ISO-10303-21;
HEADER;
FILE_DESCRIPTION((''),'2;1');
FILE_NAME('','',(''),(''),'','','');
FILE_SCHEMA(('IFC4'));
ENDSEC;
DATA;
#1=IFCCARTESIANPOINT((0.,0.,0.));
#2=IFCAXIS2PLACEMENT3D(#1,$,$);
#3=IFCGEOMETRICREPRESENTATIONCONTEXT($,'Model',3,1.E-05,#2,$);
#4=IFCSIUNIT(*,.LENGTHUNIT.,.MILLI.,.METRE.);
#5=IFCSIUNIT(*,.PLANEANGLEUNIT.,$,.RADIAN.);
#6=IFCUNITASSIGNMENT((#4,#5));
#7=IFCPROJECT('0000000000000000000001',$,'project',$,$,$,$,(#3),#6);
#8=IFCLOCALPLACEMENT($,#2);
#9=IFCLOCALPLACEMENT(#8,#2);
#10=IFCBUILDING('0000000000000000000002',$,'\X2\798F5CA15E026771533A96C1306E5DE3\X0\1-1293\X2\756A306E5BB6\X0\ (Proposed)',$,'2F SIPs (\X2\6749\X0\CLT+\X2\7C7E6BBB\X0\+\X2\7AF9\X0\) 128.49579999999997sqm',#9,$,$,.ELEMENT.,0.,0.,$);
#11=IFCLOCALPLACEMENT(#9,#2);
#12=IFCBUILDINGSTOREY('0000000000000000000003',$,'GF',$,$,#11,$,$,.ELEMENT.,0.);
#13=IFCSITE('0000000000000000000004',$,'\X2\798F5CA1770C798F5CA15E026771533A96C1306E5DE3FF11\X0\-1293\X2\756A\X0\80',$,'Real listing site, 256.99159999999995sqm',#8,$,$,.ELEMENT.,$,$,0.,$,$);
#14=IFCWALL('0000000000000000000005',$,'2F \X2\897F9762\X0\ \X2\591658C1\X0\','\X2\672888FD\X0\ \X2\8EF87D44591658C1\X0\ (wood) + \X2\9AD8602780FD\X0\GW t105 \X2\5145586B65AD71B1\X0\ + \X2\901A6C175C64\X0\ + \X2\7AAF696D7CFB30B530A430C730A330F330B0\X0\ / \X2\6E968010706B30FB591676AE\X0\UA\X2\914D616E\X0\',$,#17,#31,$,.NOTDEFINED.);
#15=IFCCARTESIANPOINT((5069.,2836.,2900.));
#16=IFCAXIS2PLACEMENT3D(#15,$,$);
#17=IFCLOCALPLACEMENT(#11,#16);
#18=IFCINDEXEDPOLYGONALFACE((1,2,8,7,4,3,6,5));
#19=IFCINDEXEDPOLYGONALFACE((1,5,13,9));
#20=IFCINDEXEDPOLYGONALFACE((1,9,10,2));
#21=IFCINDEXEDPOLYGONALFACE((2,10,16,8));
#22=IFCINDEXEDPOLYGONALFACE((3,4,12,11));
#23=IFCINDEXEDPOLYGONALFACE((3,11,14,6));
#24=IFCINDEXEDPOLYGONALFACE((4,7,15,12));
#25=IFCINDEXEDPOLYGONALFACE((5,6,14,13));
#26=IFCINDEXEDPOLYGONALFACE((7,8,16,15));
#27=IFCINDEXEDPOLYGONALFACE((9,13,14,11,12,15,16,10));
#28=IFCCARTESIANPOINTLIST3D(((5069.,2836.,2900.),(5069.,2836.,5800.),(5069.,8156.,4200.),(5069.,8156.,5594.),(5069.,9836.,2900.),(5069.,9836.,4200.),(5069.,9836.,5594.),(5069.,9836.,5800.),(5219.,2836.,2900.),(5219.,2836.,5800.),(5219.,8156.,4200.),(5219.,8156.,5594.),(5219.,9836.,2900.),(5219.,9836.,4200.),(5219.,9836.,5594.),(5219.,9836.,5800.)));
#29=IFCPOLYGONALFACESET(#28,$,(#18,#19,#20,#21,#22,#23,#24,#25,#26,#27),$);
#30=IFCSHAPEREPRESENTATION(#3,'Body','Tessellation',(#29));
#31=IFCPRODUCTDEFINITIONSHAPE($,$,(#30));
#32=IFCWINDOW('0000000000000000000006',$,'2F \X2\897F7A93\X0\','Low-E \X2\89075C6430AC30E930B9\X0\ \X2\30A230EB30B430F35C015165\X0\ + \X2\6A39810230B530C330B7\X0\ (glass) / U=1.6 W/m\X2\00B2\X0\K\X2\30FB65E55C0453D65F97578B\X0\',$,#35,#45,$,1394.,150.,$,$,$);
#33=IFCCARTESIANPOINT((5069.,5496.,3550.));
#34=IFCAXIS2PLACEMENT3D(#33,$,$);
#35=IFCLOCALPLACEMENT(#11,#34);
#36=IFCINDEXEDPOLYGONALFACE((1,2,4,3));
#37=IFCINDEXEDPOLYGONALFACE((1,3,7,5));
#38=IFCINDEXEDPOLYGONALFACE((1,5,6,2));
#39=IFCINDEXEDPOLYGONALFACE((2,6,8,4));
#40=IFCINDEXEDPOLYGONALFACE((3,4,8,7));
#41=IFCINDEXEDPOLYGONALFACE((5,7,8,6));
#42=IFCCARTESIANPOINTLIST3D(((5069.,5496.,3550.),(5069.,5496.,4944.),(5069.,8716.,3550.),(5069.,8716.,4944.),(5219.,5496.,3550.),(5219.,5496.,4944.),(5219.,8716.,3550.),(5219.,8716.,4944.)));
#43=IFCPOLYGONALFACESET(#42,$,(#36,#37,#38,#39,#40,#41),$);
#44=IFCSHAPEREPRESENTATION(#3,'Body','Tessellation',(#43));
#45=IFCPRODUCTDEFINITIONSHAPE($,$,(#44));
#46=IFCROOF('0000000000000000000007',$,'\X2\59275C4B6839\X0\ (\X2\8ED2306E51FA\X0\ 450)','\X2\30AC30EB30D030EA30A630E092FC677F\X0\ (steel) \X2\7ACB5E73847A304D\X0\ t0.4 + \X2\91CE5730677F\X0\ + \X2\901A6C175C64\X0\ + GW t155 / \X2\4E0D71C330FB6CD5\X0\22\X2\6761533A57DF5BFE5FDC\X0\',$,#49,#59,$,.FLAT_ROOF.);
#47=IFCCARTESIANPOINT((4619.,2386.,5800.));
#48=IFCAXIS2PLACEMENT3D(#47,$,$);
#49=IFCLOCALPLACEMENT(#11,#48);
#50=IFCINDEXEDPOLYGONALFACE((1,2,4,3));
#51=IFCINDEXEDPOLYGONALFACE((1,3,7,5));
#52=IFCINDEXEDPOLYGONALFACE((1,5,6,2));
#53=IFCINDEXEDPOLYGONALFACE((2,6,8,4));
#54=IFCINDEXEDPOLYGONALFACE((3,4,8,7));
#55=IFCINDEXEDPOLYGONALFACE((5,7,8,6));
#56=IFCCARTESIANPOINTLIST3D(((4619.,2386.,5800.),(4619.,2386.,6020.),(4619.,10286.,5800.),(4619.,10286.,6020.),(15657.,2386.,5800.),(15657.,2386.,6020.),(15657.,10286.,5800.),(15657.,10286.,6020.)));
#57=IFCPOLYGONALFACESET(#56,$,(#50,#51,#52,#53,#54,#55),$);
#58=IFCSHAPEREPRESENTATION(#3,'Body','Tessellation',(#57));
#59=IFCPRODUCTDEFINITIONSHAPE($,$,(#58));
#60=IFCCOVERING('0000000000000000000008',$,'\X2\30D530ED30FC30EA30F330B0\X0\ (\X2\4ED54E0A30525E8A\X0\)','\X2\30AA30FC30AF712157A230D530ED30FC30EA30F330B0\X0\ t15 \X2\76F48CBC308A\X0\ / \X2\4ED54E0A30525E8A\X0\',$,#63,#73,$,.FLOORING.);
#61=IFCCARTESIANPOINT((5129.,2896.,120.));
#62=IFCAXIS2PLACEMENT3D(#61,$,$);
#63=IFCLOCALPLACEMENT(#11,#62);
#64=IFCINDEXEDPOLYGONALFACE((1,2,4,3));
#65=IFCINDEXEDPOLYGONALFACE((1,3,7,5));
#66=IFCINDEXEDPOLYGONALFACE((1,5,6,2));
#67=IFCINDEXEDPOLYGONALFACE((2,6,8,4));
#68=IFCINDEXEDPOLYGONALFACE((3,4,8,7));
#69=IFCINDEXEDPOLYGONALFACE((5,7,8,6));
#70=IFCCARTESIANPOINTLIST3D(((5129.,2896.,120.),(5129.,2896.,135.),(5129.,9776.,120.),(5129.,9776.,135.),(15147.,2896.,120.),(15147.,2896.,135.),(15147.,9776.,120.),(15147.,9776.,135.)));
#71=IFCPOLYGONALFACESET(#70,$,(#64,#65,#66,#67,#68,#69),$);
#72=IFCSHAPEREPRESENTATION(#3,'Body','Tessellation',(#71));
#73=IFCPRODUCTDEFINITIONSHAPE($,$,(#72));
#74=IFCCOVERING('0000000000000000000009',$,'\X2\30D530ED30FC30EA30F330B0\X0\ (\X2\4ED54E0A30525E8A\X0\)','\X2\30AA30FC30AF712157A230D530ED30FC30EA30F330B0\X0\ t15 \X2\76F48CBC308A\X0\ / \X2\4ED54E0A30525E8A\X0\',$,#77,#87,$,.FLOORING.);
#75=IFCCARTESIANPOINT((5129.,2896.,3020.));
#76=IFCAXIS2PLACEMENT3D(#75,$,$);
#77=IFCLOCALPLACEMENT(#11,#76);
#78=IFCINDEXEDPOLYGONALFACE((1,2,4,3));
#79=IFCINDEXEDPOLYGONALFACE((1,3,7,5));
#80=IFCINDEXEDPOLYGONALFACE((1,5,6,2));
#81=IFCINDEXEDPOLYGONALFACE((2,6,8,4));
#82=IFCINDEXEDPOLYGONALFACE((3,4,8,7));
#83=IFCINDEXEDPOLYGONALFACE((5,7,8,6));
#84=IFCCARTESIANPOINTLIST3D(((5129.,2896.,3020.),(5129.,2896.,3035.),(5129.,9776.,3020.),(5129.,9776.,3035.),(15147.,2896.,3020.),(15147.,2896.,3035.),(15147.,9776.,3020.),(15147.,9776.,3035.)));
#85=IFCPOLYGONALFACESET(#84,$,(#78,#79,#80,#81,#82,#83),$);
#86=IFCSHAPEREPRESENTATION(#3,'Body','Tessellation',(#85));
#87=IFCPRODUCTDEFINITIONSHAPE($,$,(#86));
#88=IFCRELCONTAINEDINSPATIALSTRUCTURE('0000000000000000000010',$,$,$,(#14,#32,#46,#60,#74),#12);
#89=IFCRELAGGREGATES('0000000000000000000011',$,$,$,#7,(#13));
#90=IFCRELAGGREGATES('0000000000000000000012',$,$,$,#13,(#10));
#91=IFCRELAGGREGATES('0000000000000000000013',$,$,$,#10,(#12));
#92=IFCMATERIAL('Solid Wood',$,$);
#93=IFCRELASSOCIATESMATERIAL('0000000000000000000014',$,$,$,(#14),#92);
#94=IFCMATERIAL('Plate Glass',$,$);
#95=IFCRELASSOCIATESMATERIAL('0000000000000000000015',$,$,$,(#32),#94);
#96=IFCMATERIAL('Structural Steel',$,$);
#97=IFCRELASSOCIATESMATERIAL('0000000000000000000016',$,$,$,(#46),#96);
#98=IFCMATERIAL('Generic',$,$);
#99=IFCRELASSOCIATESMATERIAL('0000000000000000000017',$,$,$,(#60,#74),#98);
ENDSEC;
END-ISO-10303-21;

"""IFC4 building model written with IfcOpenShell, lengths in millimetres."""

from ifc_helpers import new_model, si_unit, frame, frame_2d, origin, place, context, project, spatial, rectangle, extrude, material, element, fill, save


model = new_model("IFC4")

# Units and contexts
model_context = context("Model", 3, precision=1e-05, world=origin())
ifc_project = project(units=[si_unit("LENGTHUNIT", "METRE", prefix="MILLI"), si_unit("PLANEANGLEUNIT", "RADIAN")], contexts=[model_context])

# Site, building, storey
site_placement = place(None, origin())
site = spatial("IfcSite", under=ifc_project, at=site_placement, Name="福岡県福岡市東区雁の巣１-1293番80", ObjectType="Real listing site, 256.99159999999995sqm", CompositionType="ELEMENT", RefElevation=0.0)
building_placement = place(site_placement, origin())
building = spatial("IfcBuilding", under=site, at=building_placement, Name="福岡市東区雁の巣1-1293番の家 (Proposed)", ObjectType="2F SIPs (杉CLT+籾殻+竹) 128.49579999999997sqm", CompositionType="ELEMENT", ElevationOfRefHeight=0.0, ElevationOfTerrain=0.0)
storey_placement = place(building_placement, origin())
storey = spatial("IfcBuildingStorey", under=building, at=storey_placement, Name="GF", CompositionType="ELEMENT", Elevation=0.0)

# Shared definitions
ifc_material_1 = material(Name="Solid Wood")

# Shared definitions
ifc_material_2 = material(Name="Plate Glass")

# Wall, opening, window
wall_1_placement = place(storey_placement, frame((5069.0, 2836.0, 2900.0)))
wall_1 = element("IfcWall", 1, at=wall_1_placement, inside=storey, material=ifc_material_1, Name="2F 西面 外壁", Description="木製 軸組外壁 (wood) + 高性能GW t105 充填断熱 + 通気層 + 窯業系サイディング / 準耐火・外皮UA配慮", PredefinedType="NOTDEFINED", context=model_context, shape_type="SweptSolid", body=[
    extrude(rectangle(XDim=150.0, YDim=7000.0, at=frame_2d((75.0, 3500.0))), frame((5069.0, 2836.0, 2900.0)), (0.0, 0.0, 1.0), 2900.0),
])
opening_1_placement = place(storey_placement, frame((5069.0, 5496.0, 3550.0)))
opening_1 = element("IfcOpeningElement", 2, at=opening_1_placement, cuts=wall_1, PredefinedType="NOTDEFINED", context=model_context, shape_type="SweptSolid", body=[
    extrude(rectangle(XDim=150.0, YDim=3220.0, at=frame_2d((75.0, 1610.0))), frame((5069.0, 5496.0, 3550.0)), (0.0, 0.0, 1.0), 1394.0),
])
window_1_placement = place(storey_placement, frame((5069.0, 5496.0, 3550.0)))
window_1 = element("IfcWindow", 3, at=window_1_placement, inside=storey, material=ifc_material_2, Name="2F 西窓", Description="Low-E 複層ガラス アルゴン封入 + 樹脂サッシ (glass) / U=1.6 W/m²K・日射取得型", OverallHeight=1394.0, OverallWidth=150.0, context=model_context, shape_type="SweptSolid", body=[
    extrude(rectangle(XDim=150.0, YDim=3220.0, at=frame_2d((75.0, 1610.0))), frame((5069.0, 5496.0, 3550.0)), (0.0, 0.0, 1.0), 1394.0),
])
fill(opening_1, window_1)

# Roof
ifc_material_3 = material(Name="Structural Steel")
roof_placement = place(storey_placement, frame((4619.0, 2386.0, 5800.0)))
element("IfcRoof", 4, at=roof_placement, inside=storey, material=ifc_material_3, Name="大屋根 (軒の出 450)", Description="ガルバリウム鋼板 (steel) 立平葺き t0.4 + 野地板 + 通気層 + GW t155 / 不燃・法22条区域対応", PredefinedType="FLAT_ROOF", context=model_context, shape_type="SweptSolid", body=[
    extrude(rectangle(XDim=11038.0, YDim=7900.0, at=frame_2d((5519.0, 3950.0))), frame((4619.0, 2386.0, 5800.0)), (0.0, 0.0, 1.0), 220.0),
])

# Coverings
ifc_material_4 = material(Name="Generic")
covering_1_placement = place(storey_placement, frame((5129.0, 2896.0, 120.0)))
element("IfcCovering", 5, at=covering_1_placement, inside=storey, material=ifc_material_4, Name="フローリング (仕上げ床)", Description="オーク無垢フローリング t15 直貼り / 仕上げ床", PredefinedType="FLOORING", context=model_context, shape_type="SweptSolid", body=[
    extrude(rectangle(XDim=10018.0, YDim=6880.0, at=frame_2d((5009.0, 3440.0))), frame((5129.0, 2896.0, 120.0)), (0.0, 0.0, 1.0), 15.0),
])
covering_2_placement = place(storey_placement, frame((5129.0, 2896.0, 3020.0)))
element("IfcCovering", 6, at=covering_2_placement, inside=storey, material=ifc_material_4, Name="フローリング (仕上げ床)", Description="オーク無垢フローリング t15 直貼り / 仕上げ床", PredefinedType="FLOORING", context=model_context, shape_type="SweptSolid", body=[
    extrude(rectangle(XDim=10018.0, YDim=6880.0, at=frame_2d((5009.0, 3440.0))), frame((5129.0, 2896.0, 3020.0)), (0.0, 0.0, 1.0), 15.0),
])

save(model, "model.ifc")
